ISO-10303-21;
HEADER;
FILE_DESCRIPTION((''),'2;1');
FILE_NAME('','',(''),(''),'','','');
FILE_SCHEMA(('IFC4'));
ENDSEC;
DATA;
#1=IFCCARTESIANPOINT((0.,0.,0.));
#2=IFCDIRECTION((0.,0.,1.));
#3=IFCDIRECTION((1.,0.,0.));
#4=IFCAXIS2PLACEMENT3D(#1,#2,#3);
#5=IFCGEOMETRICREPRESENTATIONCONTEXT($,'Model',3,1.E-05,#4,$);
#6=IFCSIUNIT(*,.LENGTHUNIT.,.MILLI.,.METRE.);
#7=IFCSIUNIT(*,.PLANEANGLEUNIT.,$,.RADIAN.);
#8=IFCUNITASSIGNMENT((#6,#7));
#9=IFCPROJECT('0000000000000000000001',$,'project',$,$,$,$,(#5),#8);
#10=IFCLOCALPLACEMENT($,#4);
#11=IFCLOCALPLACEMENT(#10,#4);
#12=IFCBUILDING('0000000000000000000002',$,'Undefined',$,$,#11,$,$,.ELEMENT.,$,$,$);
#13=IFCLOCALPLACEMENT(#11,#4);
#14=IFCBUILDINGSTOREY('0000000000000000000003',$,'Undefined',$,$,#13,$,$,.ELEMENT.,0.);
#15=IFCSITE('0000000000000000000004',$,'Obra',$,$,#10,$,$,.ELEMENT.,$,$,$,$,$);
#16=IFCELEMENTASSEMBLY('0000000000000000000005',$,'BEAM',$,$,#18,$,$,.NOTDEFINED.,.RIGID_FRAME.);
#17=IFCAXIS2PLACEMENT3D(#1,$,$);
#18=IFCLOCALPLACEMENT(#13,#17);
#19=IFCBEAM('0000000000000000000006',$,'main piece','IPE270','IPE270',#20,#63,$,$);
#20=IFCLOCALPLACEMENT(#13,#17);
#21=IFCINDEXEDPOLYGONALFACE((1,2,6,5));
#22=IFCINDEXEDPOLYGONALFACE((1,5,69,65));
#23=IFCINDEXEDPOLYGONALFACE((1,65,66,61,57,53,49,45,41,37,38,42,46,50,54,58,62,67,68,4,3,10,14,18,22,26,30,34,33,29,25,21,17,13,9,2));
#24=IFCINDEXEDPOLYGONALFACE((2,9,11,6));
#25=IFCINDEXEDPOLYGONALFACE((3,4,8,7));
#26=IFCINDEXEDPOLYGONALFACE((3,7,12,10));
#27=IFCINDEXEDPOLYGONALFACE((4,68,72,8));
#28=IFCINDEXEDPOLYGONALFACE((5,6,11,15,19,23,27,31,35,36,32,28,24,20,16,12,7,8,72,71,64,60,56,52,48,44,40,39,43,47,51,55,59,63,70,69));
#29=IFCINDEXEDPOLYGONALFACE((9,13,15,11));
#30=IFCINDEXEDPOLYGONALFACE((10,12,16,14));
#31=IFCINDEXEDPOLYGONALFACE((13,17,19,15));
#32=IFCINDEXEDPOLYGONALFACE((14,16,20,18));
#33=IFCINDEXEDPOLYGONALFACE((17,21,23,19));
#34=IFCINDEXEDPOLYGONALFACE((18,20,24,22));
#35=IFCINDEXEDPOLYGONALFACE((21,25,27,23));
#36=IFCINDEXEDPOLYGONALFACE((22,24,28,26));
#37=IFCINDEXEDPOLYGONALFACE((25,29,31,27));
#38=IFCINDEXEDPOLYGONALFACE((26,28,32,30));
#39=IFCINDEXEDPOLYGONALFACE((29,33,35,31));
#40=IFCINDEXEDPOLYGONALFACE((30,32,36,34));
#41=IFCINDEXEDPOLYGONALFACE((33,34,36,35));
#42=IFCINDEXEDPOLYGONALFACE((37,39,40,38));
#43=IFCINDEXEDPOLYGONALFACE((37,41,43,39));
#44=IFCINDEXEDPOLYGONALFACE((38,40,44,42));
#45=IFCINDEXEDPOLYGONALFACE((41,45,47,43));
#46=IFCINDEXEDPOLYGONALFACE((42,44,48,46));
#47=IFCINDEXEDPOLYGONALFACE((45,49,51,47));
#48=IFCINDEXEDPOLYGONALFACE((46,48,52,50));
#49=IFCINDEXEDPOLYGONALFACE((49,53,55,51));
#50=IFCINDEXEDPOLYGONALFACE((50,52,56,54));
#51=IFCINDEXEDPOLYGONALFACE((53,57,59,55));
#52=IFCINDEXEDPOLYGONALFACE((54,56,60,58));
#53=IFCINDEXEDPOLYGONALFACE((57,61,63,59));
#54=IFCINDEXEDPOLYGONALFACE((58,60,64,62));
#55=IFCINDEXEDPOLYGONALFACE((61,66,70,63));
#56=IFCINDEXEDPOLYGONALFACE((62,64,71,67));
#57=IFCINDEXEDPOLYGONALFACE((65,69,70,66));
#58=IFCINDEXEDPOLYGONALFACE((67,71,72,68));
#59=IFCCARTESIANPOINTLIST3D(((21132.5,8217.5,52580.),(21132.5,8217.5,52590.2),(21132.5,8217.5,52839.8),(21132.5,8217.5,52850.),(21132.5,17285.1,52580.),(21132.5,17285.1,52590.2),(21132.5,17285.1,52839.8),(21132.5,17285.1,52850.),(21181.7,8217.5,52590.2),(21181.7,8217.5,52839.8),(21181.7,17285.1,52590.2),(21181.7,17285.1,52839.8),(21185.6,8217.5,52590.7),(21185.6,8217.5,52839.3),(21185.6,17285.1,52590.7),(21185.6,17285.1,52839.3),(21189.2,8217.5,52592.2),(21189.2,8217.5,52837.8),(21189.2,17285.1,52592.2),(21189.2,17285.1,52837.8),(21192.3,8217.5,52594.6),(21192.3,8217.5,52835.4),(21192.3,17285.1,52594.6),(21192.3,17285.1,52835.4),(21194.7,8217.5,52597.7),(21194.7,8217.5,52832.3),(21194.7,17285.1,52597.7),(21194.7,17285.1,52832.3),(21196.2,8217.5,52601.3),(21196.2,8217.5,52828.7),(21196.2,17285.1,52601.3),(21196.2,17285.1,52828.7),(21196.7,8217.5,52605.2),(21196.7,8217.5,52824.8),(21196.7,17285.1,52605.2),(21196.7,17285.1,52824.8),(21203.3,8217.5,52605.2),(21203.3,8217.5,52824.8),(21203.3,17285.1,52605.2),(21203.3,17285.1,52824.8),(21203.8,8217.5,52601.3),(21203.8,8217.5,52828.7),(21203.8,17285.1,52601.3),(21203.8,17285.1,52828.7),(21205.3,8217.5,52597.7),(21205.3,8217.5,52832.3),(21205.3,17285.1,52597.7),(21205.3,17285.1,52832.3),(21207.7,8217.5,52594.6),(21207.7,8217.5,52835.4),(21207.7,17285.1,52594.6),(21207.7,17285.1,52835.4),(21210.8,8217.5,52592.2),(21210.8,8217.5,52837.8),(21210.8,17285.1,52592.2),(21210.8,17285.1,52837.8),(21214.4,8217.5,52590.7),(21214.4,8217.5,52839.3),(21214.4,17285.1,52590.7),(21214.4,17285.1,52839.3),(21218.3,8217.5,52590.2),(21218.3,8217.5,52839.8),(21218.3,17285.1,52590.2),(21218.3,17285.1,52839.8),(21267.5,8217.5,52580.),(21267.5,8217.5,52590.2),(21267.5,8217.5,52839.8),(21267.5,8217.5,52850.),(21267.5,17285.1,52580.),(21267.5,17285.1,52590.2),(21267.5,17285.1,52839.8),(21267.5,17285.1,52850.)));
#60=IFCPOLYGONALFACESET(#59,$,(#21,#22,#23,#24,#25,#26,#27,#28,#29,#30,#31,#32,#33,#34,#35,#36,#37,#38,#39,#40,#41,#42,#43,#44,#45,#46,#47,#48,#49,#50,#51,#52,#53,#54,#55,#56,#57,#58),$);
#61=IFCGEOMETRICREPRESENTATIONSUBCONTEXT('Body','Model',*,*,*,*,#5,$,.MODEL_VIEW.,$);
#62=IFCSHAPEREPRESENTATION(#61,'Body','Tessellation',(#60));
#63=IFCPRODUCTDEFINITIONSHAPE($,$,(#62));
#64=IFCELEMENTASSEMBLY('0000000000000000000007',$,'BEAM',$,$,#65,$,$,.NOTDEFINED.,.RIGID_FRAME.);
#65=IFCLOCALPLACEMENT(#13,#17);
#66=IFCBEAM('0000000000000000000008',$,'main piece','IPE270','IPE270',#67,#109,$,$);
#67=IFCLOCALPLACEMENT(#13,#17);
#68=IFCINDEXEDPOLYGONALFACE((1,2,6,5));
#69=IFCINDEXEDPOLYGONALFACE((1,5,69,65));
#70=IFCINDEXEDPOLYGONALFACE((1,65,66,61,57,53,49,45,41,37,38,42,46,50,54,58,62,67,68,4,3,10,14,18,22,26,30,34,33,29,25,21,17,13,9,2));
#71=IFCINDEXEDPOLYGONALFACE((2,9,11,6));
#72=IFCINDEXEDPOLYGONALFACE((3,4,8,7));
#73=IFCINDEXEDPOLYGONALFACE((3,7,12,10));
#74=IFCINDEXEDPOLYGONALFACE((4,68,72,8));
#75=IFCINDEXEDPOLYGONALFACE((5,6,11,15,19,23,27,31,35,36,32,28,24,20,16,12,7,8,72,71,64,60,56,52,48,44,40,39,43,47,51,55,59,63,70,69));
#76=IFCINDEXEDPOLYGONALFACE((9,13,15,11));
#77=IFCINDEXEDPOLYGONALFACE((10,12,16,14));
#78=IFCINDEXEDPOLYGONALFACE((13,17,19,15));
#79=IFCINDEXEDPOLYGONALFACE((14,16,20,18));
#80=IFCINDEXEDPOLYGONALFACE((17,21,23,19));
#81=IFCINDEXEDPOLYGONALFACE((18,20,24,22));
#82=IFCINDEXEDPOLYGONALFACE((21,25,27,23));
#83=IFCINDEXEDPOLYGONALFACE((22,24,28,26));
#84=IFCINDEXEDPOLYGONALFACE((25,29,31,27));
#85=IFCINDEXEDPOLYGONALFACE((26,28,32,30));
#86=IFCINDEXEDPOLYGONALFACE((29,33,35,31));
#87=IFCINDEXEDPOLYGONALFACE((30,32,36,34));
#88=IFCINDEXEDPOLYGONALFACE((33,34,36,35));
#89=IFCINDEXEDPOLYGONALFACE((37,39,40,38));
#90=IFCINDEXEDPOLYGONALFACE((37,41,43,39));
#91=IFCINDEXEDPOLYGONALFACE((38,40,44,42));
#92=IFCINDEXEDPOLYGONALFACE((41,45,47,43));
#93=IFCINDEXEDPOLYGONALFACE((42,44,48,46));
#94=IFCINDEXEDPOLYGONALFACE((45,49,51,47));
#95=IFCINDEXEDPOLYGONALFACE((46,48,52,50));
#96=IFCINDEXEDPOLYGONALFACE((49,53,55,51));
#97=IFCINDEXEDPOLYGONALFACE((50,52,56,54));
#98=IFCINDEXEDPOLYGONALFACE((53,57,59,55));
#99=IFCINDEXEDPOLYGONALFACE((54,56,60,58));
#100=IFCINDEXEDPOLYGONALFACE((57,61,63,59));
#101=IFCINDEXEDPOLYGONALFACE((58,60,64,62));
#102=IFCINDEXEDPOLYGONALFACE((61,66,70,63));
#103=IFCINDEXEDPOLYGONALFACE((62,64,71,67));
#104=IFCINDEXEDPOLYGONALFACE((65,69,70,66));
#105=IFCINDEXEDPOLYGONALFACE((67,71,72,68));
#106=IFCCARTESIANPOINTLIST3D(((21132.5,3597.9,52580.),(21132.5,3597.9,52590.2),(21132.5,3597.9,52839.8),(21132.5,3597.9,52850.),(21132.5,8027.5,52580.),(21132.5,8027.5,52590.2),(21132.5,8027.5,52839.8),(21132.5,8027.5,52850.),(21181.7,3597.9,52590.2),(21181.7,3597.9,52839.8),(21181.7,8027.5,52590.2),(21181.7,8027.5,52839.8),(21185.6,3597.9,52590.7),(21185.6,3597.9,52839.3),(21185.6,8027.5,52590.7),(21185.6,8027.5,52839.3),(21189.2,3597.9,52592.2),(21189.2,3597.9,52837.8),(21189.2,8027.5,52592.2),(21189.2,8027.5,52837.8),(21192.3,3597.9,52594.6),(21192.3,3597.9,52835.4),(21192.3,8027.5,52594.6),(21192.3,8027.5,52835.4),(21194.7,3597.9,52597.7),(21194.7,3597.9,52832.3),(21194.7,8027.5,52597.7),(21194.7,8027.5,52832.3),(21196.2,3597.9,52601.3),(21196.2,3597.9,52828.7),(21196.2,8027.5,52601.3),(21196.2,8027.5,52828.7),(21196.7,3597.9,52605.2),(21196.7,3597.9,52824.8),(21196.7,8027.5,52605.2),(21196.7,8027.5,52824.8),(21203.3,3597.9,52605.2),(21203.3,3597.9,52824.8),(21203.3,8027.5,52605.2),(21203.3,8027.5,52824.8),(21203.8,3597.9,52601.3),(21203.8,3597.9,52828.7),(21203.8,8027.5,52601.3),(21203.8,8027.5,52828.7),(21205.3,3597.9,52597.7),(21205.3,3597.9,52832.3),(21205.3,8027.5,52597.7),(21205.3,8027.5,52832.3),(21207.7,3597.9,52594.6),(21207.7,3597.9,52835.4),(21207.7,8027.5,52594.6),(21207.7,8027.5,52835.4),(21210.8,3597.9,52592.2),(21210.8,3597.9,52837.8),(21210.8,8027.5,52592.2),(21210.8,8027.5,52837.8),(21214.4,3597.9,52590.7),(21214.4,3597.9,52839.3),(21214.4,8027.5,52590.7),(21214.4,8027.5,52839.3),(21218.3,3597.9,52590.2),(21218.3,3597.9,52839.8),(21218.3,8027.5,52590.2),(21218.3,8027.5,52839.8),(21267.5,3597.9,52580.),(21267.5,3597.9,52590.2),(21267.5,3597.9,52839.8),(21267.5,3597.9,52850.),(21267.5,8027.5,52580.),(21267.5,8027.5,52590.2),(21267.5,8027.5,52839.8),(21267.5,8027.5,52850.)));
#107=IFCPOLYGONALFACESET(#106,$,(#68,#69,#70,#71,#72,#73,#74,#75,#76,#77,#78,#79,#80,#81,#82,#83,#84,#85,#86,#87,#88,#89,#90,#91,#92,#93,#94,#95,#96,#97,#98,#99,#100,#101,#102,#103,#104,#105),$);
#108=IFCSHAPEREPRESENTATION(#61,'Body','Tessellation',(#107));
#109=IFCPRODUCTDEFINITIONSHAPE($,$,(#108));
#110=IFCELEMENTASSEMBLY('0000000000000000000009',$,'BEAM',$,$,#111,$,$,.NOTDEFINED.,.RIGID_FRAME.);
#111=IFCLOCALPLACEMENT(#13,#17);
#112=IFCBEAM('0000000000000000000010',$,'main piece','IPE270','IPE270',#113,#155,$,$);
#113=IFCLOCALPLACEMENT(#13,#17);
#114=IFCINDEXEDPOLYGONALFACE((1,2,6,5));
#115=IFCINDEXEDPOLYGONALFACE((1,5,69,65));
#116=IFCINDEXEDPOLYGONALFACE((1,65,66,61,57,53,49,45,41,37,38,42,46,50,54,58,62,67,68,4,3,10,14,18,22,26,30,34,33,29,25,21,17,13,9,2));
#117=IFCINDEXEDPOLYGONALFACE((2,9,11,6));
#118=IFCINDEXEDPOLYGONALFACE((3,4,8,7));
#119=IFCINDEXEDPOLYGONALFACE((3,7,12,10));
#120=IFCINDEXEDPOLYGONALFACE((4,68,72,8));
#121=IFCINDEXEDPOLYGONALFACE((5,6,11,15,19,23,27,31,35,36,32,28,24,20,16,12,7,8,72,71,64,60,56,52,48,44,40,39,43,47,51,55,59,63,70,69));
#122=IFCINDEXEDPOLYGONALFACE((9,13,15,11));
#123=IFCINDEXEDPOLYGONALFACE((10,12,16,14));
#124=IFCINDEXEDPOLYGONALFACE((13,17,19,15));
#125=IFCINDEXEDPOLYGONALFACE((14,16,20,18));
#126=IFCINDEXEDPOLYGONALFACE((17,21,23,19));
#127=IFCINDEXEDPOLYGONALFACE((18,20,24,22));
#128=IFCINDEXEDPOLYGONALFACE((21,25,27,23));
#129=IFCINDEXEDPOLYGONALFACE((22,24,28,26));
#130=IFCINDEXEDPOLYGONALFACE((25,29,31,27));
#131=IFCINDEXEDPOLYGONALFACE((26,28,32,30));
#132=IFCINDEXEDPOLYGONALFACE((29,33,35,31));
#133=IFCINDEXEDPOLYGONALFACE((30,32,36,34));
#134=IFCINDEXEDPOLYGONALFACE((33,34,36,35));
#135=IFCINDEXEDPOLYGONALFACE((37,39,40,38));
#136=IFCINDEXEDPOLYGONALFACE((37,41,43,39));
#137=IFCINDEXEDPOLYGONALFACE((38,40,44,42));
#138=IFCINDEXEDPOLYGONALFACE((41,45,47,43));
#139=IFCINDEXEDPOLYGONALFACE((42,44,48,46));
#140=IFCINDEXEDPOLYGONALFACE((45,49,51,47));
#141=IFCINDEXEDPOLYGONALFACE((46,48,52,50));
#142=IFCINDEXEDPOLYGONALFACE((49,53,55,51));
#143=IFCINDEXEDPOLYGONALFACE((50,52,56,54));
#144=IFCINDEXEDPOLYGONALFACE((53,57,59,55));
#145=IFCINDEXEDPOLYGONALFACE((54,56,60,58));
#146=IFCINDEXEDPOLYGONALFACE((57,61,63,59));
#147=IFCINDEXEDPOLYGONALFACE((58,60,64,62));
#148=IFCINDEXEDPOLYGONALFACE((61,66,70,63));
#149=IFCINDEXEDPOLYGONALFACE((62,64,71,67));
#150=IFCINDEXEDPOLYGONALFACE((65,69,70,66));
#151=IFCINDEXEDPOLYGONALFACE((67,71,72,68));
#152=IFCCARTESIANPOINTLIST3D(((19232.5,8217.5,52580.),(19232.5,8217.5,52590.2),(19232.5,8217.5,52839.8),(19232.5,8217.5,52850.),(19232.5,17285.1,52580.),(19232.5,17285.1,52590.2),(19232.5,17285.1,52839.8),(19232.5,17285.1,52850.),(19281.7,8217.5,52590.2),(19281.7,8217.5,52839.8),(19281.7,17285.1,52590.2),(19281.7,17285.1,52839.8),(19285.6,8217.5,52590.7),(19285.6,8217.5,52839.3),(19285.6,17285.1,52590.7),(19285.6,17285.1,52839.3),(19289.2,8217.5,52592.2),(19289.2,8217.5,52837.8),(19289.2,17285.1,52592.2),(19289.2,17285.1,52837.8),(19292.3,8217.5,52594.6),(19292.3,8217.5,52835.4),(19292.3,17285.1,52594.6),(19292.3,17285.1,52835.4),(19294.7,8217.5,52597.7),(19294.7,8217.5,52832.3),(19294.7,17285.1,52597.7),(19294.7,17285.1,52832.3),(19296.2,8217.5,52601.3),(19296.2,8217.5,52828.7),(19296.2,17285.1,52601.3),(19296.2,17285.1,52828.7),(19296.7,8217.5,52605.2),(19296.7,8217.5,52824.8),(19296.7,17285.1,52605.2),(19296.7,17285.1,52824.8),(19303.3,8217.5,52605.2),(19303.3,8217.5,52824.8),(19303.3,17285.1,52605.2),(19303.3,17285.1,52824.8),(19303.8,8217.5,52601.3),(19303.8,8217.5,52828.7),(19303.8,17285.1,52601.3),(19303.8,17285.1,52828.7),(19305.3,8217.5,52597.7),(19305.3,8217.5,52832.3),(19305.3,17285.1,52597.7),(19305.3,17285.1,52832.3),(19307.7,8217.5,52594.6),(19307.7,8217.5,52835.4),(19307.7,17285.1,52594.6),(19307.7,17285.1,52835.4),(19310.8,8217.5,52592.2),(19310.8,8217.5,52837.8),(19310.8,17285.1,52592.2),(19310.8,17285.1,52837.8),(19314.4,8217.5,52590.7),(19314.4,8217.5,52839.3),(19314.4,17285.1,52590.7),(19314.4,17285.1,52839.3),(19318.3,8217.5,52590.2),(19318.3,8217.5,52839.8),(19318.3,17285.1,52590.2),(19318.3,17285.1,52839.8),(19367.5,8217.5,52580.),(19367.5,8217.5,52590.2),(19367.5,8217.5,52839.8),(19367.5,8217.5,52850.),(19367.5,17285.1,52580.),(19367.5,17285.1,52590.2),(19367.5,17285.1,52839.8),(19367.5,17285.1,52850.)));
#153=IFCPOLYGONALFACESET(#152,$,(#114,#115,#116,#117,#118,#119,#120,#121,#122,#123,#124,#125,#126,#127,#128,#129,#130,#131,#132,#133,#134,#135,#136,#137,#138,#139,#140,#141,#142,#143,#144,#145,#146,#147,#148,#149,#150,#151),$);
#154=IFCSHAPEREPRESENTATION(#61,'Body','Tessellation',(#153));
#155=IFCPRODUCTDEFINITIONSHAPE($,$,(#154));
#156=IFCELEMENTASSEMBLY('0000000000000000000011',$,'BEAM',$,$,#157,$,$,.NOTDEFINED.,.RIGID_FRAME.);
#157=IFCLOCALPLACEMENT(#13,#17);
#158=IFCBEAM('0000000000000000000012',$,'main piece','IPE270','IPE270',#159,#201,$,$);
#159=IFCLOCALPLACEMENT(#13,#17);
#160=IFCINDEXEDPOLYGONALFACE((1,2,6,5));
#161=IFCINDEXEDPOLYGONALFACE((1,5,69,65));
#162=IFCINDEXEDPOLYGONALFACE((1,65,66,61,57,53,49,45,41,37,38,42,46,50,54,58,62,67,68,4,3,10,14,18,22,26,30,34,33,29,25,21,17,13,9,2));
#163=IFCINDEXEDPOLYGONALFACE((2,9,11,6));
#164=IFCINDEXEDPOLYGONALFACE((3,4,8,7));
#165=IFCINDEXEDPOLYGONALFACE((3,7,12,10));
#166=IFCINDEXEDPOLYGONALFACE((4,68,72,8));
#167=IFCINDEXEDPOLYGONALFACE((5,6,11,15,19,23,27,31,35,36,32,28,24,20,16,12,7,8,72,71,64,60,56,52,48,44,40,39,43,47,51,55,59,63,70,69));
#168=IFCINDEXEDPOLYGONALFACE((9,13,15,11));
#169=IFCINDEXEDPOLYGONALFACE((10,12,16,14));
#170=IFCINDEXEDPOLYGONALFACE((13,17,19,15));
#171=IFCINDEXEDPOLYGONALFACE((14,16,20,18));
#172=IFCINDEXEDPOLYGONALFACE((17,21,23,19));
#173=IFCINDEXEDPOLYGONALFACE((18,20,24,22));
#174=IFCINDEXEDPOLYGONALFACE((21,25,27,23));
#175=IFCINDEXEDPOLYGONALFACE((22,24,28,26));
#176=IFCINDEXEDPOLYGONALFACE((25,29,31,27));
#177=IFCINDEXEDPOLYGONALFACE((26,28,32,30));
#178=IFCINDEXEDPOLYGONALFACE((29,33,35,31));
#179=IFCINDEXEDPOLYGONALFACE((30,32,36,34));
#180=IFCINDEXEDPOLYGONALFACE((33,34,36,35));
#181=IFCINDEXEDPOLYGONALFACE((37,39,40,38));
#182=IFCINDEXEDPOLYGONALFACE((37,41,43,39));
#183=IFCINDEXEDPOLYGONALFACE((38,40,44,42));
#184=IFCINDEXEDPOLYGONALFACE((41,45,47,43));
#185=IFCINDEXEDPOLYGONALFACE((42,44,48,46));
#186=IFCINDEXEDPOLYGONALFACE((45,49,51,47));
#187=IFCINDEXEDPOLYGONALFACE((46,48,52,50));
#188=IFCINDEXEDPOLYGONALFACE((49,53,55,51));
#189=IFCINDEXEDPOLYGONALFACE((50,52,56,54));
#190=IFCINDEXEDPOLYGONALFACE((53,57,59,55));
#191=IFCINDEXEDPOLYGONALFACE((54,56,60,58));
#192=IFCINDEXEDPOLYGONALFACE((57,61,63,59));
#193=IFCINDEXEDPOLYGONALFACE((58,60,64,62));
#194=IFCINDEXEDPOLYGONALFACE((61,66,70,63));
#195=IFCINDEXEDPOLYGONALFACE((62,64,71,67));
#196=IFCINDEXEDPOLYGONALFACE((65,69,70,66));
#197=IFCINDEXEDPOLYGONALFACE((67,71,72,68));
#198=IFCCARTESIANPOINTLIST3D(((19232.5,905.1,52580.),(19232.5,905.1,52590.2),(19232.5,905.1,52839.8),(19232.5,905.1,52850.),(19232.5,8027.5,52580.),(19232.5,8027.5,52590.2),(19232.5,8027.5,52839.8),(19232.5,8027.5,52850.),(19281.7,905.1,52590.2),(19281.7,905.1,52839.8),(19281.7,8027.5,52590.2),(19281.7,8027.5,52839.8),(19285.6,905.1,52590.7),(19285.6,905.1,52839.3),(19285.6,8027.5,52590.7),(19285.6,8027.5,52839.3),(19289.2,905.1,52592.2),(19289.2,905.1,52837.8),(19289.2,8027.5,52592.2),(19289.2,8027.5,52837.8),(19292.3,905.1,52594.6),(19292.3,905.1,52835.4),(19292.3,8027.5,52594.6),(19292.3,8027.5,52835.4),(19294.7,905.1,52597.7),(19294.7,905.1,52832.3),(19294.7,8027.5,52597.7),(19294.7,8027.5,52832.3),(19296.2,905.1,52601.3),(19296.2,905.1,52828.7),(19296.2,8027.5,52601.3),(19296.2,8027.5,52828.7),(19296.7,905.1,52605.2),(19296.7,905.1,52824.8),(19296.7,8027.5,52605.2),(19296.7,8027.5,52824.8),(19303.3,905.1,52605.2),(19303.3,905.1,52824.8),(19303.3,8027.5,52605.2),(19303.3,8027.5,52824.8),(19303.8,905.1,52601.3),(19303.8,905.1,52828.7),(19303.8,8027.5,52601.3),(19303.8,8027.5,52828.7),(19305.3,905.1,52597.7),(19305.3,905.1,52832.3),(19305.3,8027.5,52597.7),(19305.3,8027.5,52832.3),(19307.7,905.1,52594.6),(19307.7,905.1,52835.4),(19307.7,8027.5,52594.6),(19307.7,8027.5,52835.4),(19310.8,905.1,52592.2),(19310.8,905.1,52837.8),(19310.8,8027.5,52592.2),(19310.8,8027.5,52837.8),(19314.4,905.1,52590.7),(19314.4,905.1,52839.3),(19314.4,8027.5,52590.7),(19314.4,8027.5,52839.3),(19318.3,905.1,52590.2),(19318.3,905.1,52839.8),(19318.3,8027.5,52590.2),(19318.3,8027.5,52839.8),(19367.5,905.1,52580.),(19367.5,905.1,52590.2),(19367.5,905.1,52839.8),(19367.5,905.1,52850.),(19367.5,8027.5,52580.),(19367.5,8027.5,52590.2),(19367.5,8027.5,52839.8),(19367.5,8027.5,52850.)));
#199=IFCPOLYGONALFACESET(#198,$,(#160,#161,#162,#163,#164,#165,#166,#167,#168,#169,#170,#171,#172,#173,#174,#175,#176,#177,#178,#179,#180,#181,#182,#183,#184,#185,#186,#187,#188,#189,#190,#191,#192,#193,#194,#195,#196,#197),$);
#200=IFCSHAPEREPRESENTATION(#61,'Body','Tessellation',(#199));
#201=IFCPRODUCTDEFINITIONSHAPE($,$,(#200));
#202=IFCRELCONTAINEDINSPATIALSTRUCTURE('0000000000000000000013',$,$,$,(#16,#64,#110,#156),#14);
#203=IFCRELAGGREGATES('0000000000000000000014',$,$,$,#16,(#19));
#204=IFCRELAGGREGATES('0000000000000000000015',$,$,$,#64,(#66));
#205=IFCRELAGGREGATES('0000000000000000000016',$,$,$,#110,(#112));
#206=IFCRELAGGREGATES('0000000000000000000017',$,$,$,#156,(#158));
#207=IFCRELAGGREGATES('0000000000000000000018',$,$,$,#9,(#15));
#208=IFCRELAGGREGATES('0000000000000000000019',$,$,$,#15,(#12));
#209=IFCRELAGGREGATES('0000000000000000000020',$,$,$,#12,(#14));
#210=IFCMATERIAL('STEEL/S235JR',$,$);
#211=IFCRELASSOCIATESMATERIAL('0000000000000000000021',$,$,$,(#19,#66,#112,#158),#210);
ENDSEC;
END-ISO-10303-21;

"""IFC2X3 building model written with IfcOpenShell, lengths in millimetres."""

from ifc_helpers import new_model, si_unit, frame, origin_with_axes, origin_2d_with_axis, place, context, subcontext, project, spatial, i_section, extrude, material, element, aggregate, save


model = new_model("IFC2X3")

# Units and contexts
model_context = context("Model", 3, precision=1e-05, world=origin_with_axes())
body_context = subcontext(model_context, "Body", "Model", "MODEL_VIEW")
ifc_project = project(units=[si_unit("LENGTHUNIT", "METRE", prefix="MILLI"), si_unit("PLANEANGLEUNIT", "RADIAN")], contexts=[model_context])

# Site, building, storey
site_placement = place(None, origin_with_axes())
site = spatial("IfcSite", under=ifc_project, at=site_placement, Name="Obra", CompositionType="ELEMENT")
building_placement = place(site_placement, origin_with_axes())
building = spatial("IfcBuilding", under=site, at=building_placement, Name="Undefined", CompositionType="ELEMENT")
storey_placement = place(building_placement, origin_with_axes())
storey = spatial("IfcBuildingStorey", under=building, at=storey_placement, Name="Undefined", CompositionType="ELEMENT", Elevation=0.0)

# Shared definitions
ifc_material_1 = material(Name="STEEL/S235JR")

# Element assemblies, beams
assembly_1_placement = place(storey_placement, origin_with_axes())
assembly_1 = element("IfcElementAssembly", 1, at=assembly_1_placement, inside=storey, Name="BEAM", AssemblyPlace="NOTDEFINED", PredefinedType="RIGID_FRAME")
beam_1_placement = place(assembly_1_placement, frame((21200.0, 8217.5, 52715.0), z_axis=(0.0, 0.0, 1.0), x_axis=(0.0, 1.0, 0.0)))
beam_1 = element("IfcBeam", 2, at=beam_1_placement, material=ifc_material_1, Name="main piece", Description="IPE270", ObjectType="IPE270", context=body_context, shape_type="SweptSolid", body=[
    extrude(i_section(OverallWidth=135.0, OverallDepth=270.0, WebThickness=6.6, FlangeThickness=10.2, FilletRadius=15.0, at=origin_2d_with_axis()), frame((9067.6, 0.0, 0.0), z_axis=(-1.0, 0.0, 0.0), x_axis=(0.0, -1.0, 0.0)), (0.0, 0.0, 1.0), 9067.6),
])
aggregate(assembly_1, [beam_1])
assembly_2_placement = place(storey_placement, origin_with_axes())
assembly_2 = element("IfcElementAssembly", 3, at=assembly_2_placement, inside=storey, Name="BEAM", AssemblyPlace="NOTDEFINED", PredefinedType="RIGID_FRAME")
beam_2_placement = place(assembly_2_placement, frame((21200.0, 3598.0, 52715.0), z_axis=(0.0, 0.0, 1.0), x_axis=(0.0, 1.0, 0.0)))
beam_2 = element("IfcBeam", 4, at=beam_2_placement, material=ifc_material_1, Name="main piece", Description="IPE270", ObjectType="IPE270", context=body_context, shape_type="SweptSolid", body=[
    extrude(i_section(OverallWidth=135.0, OverallDepth=270.0, WebThickness=6.6, FlangeThickness=10.2, FilletRadius=15.0, at=origin_2d_with_axis()), frame((4429.6, 0.0, 0.0), z_axis=(-1.0, 0.0, 0.0), x_axis=(0.0, -1.0, 0.0)), (0.0, 0.0, 1.0), 4429.6),
])
aggregate(assembly_2, [beam_2])
assembly_3_placement = place(storey_placement, origin_with_axes())
assembly_3 = element("IfcElementAssembly", 5, at=assembly_3_placement, inside=storey, Name="BEAM", AssemblyPlace="NOTDEFINED", PredefinedType="RIGID_FRAME")
beam_3_placement = place(assembly_3_placement, frame((19300.0, 8217.5, 52715.0), z_axis=(0.0, 0.0, 1.0), x_axis=(0.0, 1.0, 0.0)))
beam_3 = element("IfcBeam", 6, at=beam_3_placement, material=ifc_material_1, Name="main piece", Description="IPE270", ObjectType="IPE270", context=body_context, shape_type="SweptSolid", body=[
    extrude(i_section(OverallWidth=135.0, OverallDepth=270.0, WebThickness=6.6, FlangeThickness=10.2, FilletRadius=15.0, at=origin_2d_with_axis()), frame((9067.6, 0.0, 0.0), z_axis=(-1.0, 0.0, 0.0), x_axis=(0.0, -1.0, 0.0)), (0.0, 0.0, 1.0), 9067.6),
])
aggregate(assembly_3, [beam_3])
assembly_4_placement = place(storey_placement, origin_with_axes())
assembly_4 = element("IfcElementAssembly", 7, at=assembly_4_placement, inside=storey, Name="BEAM", AssemblyPlace="NOTDEFINED", PredefinedType="RIGID_FRAME")
beam_4_placement = place(assembly_4_placement, frame((19300.0, 905.1, 52715.0), z_axis=(0.0, 0.0, 1.0), x_axis=(0.0, 1.0, 0.0)))
beam_4 = element("IfcBeam", 8, at=beam_4_placement, material=ifc_material_1, Name="main piece", Description="IPE270", ObjectType="IPE270", context=body_context, shape_type="SweptSolid", body=[
    extrude(i_section(OverallWidth=135.0, OverallDepth=270.0, WebThickness=6.6, FlangeThickness=10.2, FilletRadius=15.0, at=origin_2d_with_axis()), frame((7122.4, 0.0, 0.0), z_axis=(-1.0, 0.0, 0.0), x_axis=(0.0, -1.0, 0.0)), (0.0, 0.0, 1.0), 7122.4),
])
aggregate(assembly_4, [beam_4])

save(model, "model.ifc")
